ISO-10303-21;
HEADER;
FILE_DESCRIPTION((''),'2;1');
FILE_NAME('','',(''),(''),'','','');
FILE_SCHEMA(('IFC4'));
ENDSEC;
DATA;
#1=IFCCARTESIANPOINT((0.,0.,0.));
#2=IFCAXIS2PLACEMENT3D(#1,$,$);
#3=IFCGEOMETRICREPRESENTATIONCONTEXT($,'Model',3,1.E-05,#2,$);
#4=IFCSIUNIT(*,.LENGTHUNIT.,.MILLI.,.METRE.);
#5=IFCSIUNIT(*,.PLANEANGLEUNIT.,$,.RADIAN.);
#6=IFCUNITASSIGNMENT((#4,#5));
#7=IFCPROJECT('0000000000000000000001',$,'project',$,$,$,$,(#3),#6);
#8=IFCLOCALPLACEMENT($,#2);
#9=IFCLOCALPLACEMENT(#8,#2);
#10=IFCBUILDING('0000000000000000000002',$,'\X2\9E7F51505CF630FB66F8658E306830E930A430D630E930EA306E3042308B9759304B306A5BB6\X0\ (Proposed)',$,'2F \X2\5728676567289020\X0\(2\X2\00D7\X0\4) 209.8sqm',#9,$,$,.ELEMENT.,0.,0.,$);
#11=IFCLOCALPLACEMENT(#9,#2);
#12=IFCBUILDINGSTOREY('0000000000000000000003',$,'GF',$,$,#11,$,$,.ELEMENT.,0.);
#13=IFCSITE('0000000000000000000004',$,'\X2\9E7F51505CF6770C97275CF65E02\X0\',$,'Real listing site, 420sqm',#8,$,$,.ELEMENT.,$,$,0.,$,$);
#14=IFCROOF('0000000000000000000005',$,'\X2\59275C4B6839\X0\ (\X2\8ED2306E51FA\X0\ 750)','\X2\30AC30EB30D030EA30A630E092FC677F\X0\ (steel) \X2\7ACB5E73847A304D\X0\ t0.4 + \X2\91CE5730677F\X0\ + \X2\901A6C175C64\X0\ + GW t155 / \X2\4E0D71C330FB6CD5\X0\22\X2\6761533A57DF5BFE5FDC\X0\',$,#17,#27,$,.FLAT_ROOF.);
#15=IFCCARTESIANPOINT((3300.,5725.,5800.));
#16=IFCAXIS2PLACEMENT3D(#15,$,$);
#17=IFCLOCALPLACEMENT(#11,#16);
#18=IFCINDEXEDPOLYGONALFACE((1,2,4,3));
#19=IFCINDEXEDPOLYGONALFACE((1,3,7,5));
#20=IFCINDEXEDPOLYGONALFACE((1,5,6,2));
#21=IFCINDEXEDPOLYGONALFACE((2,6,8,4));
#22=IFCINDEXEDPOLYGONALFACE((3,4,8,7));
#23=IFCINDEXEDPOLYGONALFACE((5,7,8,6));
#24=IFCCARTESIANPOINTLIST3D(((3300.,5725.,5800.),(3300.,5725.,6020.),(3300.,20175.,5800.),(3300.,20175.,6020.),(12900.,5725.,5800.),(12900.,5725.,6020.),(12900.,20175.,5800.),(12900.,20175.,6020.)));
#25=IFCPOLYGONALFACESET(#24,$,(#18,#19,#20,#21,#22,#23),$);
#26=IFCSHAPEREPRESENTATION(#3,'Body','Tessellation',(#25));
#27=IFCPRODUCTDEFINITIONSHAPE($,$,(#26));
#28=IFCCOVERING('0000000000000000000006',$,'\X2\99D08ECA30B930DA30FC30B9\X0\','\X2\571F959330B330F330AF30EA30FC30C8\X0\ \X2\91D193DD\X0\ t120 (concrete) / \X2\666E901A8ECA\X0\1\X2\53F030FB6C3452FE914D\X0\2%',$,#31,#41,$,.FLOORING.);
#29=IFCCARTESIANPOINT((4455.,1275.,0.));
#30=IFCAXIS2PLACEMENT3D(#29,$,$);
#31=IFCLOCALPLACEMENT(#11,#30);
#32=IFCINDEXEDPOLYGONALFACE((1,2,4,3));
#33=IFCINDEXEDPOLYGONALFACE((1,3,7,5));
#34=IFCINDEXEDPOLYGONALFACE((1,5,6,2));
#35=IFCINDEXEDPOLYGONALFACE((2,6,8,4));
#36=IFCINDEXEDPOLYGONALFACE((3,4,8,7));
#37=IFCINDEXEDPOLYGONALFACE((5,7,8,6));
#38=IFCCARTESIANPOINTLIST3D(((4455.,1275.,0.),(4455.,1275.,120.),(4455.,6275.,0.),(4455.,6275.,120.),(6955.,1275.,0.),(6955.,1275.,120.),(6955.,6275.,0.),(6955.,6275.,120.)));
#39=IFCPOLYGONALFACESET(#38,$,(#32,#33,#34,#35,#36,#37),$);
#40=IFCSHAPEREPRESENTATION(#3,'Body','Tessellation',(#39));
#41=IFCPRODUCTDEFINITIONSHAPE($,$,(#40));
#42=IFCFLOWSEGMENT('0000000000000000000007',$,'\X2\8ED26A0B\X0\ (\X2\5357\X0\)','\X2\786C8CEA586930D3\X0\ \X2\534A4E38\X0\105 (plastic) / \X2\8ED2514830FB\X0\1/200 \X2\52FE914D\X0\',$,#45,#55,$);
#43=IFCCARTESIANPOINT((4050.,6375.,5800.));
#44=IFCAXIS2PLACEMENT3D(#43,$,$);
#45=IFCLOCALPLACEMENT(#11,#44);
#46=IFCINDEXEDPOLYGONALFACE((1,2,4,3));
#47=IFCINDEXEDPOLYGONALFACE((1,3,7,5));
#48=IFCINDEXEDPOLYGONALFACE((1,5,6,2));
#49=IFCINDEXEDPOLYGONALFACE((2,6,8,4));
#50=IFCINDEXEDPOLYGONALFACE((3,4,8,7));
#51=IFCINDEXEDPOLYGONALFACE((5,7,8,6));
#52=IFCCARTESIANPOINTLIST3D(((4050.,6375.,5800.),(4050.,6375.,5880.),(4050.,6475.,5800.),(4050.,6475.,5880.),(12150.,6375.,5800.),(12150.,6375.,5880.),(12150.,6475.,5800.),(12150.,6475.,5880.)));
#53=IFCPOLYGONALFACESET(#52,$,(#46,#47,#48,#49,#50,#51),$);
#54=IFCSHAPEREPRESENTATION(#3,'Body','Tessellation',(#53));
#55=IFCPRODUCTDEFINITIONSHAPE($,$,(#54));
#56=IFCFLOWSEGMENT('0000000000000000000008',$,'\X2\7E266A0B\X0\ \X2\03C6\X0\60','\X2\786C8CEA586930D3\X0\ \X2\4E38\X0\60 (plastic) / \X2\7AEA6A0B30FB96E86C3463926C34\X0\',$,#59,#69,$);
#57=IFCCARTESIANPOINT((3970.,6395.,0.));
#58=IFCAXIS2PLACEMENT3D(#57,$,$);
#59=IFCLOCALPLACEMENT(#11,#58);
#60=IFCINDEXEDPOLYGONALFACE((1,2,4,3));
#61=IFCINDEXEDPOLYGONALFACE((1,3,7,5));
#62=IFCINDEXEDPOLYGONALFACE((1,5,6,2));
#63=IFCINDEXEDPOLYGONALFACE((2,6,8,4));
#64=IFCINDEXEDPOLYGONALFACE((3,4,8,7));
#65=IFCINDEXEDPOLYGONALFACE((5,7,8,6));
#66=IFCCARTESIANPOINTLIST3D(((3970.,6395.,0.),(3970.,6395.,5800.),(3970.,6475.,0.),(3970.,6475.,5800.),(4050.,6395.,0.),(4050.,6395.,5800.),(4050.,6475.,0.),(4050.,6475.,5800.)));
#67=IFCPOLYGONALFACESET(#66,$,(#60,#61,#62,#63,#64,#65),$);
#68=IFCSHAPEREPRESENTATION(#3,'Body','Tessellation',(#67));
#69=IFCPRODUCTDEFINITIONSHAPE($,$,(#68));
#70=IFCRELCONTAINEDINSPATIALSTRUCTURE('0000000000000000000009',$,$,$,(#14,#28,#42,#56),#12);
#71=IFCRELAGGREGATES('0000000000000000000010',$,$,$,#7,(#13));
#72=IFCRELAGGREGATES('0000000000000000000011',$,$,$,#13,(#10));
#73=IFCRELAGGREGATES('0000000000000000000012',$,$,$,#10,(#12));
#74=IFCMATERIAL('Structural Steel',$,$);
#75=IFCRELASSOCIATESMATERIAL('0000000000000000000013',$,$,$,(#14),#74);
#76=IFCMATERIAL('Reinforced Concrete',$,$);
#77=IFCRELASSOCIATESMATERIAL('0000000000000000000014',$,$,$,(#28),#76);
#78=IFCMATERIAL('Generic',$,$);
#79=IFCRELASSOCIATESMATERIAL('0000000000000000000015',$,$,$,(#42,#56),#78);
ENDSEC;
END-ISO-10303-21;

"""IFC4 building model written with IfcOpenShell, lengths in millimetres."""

from ifc_helpers import new_model, si_unit, frame, frame_2d, origin, place, context, project, spatial, rectangle, extrude, material, element, save


model = new_model("IFC4")

# Units and contexts
model_context = context("Model", 3, precision=1e-05, world=origin())
ifc_project = project(units=[si_unit("LENGTHUNIT", "METRE", prefix="MILLI"), si_unit("PLANEANGLEUNIT", "RADIAN")], contexts=[model_context])

# Site, building, storey
site_placement = place(None, origin())
site = spatial("IfcSite", under=ifc_project, at=site_placement, Name="鹿児島県霧島市", ObjectType="Real listing site, 420sqm", CompositionType="ELEMENT", RefElevation=0.0)
building_placement = place(site_placement, origin())
building = spatial("IfcBuilding", under=site, at=building_placement, Name="鹿児島・書斎とライブラリのある静かな家 (Proposed)", ObjectType="2F 在来木造(2×4) 209.8sqm", CompositionType="ELEMENT", ElevationOfRefHeight=0.0, ElevationOfTerrain=0.0)
storey_placement = place(building_placement, origin())
storey = spatial("IfcBuildingStorey", under=building, at=storey_placement, Name="GF", CompositionType="ELEMENT", Elevation=0.0)

# Shared definitions
ifc_material_1 = material(Name="Reinforced Concrete")

# Roof
ifc_material_2 = material(Name="Structural Steel")
roof_placement = place(storey_placement, frame((3300.0, 5725.0, 5800.0)))
element("IfcRoof", 1, at=roof_placement, inside=storey, material=ifc_material_2, Name="大屋根 (軒の出 750)", Description="ガルバリウム鋼板 (steel) 立平葺き t0.4 + 野地板 + 通気層 + GW t155 / 不燃・法22条区域対応", PredefinedType="FLAT_ROOF", context=model_context, shape_type="SweptSolid", body=[
    extrude(rectangle(XDim=9600.0, YDim=14450.0, at=frame_2d((4800.0, 7225.0))), frame((3300.0, 5725.0, 5800.0)), (0.0, 0.0, 1.0), 220.0),
])

# Covering
covering_placement = place(storey_placement, frame((4455.0, 1275.0, 0.0)))
element("IfcCovering", 2, at=covering_placement, inside=storey, material=ifc_material_1, Name="駐車スペース", Description="土間コンクリート 金鏝 t120 (concrete) / 普通車1台・水勾配2%", PredefinedType="FLOORING", context=model_context, shape_type="SweptSolid", body=[
    extrude(rectangle(XDim=2500.0, YDim=5000.0, at=frame_2d((1250.0, 2500.0))), frame((4455.0, 1275.0, 0.0)), (0.0, 0.0, 1.0), 120.0),
])

# Flow segments
ifc_material_3 = material(Name="Generic")
flow_segment_1_placement = place(storey_placement, frame((4050.0, 6375.0, 5800.0)))
element("IfcFlowSegment", 3, at=flow_segment_1_placement, inside=storey, material=ifc_material_3, Name="軒樋 (南)", Description="硬質塩ビ 半丸105 (plastic) / 軒先・1/200 勾配", context=model_context, shape_type="SweptSolid", body=[
    extrude(rectangle(XDim=8100.0, YDim=100.0, at=frame_2d((4050.0, 50.0))), frame((4050.0, 6375.0, 5800.0)), (0.0, 0.0, 1.0), 80.0),
])
flow_segment_2_placement = place(storey_placement, frame((3970.0, 6395.0, 0.0)))
element("IfcFlowSegment", 4, at=flow_segment_2_placement, inside=storey, material=ifc_material_3, Name="縦樋 φ60", Description="硬質塩ビ 丸60 (plastic) / 竪樋・雨水排水", context=model_context, shape_type="SweptSolid", body=[
    extrude(rectangle(XDim=80.0, YDim=80.0, at=frame_2d((40.0, 40.0))), frame((3970.0, 6395.0, 0.0)), (0.0, 0.0, 1.0), 5800.0),
])

save(model, "model.ifc")
